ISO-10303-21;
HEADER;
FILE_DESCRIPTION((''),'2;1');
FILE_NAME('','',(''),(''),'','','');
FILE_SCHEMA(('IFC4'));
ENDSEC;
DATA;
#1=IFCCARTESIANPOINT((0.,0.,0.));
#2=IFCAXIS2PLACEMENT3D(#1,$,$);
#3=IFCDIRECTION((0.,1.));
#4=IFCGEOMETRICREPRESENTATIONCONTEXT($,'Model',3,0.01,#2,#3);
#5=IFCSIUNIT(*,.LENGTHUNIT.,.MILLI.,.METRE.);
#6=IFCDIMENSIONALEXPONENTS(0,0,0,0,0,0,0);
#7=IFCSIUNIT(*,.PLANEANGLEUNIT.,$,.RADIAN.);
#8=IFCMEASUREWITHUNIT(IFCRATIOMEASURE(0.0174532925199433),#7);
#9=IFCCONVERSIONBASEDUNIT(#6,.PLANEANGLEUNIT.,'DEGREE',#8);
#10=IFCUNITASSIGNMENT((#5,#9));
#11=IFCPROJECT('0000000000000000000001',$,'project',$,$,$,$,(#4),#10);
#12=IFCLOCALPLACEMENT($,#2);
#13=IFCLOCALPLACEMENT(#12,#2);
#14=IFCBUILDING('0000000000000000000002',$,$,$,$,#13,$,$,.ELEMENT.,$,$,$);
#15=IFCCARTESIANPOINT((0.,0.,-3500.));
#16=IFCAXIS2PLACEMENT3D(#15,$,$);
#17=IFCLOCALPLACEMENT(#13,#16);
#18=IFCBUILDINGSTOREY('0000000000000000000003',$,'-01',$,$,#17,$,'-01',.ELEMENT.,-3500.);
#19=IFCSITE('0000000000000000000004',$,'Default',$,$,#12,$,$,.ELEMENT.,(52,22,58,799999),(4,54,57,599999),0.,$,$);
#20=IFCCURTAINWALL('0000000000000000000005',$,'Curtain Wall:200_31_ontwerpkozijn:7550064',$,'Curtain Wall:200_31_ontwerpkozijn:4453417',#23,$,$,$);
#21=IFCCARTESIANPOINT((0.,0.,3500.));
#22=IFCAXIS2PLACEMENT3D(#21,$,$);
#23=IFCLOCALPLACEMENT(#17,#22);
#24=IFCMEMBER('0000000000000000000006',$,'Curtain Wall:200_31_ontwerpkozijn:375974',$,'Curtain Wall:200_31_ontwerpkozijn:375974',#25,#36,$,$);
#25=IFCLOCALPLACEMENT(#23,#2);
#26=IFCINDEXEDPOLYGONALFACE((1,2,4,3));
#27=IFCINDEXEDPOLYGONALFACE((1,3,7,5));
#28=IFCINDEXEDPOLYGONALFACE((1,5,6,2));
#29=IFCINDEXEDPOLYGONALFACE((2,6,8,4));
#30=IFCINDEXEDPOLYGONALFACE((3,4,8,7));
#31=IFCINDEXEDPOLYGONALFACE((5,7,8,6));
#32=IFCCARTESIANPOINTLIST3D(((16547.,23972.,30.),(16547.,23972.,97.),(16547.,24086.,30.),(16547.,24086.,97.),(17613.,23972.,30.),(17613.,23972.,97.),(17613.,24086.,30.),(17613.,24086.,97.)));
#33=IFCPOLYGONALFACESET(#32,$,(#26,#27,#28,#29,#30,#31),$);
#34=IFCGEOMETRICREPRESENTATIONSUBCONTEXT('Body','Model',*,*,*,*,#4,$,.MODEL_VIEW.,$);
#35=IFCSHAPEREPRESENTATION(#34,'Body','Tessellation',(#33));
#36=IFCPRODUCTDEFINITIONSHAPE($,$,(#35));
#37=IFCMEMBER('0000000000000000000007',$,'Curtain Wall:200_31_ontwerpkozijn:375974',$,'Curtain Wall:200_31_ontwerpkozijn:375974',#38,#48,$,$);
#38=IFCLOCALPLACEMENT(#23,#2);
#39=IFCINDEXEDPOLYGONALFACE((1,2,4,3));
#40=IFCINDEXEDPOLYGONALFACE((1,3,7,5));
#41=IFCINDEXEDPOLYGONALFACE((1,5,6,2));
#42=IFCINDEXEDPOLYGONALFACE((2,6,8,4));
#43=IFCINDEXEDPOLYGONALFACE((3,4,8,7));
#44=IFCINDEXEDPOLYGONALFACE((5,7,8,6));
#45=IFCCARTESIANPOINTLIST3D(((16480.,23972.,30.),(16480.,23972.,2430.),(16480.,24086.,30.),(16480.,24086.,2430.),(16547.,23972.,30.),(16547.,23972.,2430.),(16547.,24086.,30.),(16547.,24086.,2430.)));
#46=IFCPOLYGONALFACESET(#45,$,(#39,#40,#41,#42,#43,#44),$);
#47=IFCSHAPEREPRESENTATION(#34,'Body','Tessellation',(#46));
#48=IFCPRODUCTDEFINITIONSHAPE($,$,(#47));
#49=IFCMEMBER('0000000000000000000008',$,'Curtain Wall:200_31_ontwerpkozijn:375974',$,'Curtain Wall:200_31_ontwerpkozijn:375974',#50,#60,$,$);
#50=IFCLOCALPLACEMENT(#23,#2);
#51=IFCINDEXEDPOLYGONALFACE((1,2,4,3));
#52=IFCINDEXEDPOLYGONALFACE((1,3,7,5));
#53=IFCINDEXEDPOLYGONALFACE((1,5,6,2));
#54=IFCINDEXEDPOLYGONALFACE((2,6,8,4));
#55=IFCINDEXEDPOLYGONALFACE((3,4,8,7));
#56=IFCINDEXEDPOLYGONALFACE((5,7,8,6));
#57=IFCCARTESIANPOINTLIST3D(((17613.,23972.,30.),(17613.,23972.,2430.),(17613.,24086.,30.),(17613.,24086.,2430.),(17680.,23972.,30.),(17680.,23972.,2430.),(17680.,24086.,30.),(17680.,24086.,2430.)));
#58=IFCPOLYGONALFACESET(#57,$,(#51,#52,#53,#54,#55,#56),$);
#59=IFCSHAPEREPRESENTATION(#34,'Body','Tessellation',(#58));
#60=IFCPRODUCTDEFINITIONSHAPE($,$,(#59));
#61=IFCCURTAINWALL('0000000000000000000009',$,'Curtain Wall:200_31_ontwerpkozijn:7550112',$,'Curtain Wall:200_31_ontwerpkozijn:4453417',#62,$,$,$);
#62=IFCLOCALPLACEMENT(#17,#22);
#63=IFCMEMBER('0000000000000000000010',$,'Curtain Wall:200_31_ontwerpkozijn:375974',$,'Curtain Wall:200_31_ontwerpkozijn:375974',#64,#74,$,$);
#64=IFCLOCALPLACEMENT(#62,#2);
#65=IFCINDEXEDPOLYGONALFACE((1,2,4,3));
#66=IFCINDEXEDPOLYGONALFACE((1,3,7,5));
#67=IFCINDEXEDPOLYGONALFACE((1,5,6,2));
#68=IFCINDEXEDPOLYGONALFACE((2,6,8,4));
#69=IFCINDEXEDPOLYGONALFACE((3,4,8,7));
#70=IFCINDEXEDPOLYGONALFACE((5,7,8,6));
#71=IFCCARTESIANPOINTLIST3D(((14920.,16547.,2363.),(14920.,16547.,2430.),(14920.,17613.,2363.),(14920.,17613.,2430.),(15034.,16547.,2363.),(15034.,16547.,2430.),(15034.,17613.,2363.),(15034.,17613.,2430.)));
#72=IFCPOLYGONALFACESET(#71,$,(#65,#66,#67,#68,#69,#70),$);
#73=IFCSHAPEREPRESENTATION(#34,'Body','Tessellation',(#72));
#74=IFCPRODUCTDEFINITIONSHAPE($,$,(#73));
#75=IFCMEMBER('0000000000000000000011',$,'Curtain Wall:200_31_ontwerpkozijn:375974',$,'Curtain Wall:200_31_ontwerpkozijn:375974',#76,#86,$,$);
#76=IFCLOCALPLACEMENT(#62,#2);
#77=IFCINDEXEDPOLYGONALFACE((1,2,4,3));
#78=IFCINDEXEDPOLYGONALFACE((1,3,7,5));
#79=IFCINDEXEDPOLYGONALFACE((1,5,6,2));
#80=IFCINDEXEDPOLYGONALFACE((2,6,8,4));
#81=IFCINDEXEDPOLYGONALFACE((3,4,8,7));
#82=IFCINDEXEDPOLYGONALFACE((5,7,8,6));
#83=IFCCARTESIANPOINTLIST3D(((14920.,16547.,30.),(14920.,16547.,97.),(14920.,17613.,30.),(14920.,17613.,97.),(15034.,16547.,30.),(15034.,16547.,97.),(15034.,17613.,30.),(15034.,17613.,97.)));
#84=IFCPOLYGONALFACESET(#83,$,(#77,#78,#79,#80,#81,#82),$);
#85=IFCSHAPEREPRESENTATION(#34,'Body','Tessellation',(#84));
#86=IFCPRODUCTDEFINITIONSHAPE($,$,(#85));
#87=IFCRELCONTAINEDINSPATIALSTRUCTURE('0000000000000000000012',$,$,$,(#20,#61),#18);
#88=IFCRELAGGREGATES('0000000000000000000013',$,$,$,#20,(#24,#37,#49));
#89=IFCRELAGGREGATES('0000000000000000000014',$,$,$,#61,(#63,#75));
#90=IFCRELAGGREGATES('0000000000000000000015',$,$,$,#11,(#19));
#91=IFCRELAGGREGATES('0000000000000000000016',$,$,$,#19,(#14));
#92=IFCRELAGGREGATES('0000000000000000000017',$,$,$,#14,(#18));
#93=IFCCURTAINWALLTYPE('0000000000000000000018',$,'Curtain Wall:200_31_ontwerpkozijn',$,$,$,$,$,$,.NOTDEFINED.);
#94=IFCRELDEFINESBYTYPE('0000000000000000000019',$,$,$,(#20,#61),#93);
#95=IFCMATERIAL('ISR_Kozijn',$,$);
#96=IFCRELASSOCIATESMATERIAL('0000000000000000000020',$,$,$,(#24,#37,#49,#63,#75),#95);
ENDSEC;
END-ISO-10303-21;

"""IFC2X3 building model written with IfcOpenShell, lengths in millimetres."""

from ifc_helpers import new_model, entity, si_unit, converted_unit, direction, frame, frame_2d, origin, origin_2d_with_axis, place, context, subcontext, project, spatial, rectangle, extrude, material, type_object, element, aggregate, save


model = new_model("IFC2X3")

# Units and contexts
model_context = context("Model", 3, precision=0.01, world=origin(), true_north=direction((0.0, 1.0)))
body_context = subcontext(model_context, "Body", "Model", "MODEL_VIEW")
ifc_project = project(units=[si_unit("LENGTHUNIT", "METRE", prefix="MILLI"), converted_unit("PLANEANGLEUNIT", "DEGREE", entity("IfcRatioMeasure", 0.0174532925199433), si_unit("PLANEANGLEUNIT", "RADIAN"), dimensions=[0, 0, 0, 0, 0, 0, 0])], contexts=[model_context])

# Site, building, storey
site_placement = place(None, origin())
site = spatial("IfcSite", under=ifc_project, at=site_placement, Name="Default", CompositionType="ELEMENT", RefLatitude=(52, 22, 58, 799999), RefLongitude=(4, 54, 57, 599999), RefElevation=0.0)
building_placement = place(site_placement, origin())
building = spatial("IfcBuilding", under=site, at=building_placement, CompositionType="ELEMENT")
storey_placement = place(building_placement, frame((0.0, 0.0, -3500.0)))
storey = spatial("IfcBuildingStorey", under=building, at=storey_placement, Name="-01", LongName="-01", CompositionType="ELEMENT", Elevation=-3500.0)

# Shared definitions
curtain_wall_type = type_object("IfcCurtainWallType", Name="Curtain Wall:200_31_ontwerpkozijn", PredefinedType="NOTDEFINED")
ifc_material = material(Name="ISR_Kozijn")

# Curtain walls, members
curtain_wall_1_placement = place(storey_placement, frame((0.0, 0.0, 3500.0)))
curtain_wall_1 = element("IfcCurtainWall", 1, at=curtain_wall_1_placement, inside=storey, type_object=curtain_wall_type, Name="Curtain Wall:200_31_ontwerpkozijn:7550064", ObjectType="Curtain Wall:200_31_ontwerpkozijn:4453417")
member_1_placement = place(curtain_wall_1_placement, origin())
member_1 = element("IfcMember", 2, at=member_1_placement, material=ifc_material, Name="Curtain Wall:200_31_ontwerpkozijn:375974", ObjectType="Curtain Wall:200_31_ontwerpkozijn:375974", context=body_context, shape_type="SweptSolid", body=[
    extrude(rectangle(XDim=67.0, YDim=114.0, at=origin_2d_with_axis()), frame((17613.0, 24029.0, 63.5), z_axis=(-1.0, 0.0, 0.0), x_axis=(0.0, 0.0, -1.0)), (0.0, 0.0, 1.0), 1066.0),
])
member_2_placement = place(curtain_wall_1_placement, origin())
member_2 = element("IfcMember", 3, at=member_2_placement, material=ifc_material, Name="Curtain Wall:200_31_ontwerpkozijn:375974", ObjectType="Curtain Wall:200_31_ontwerpkozijn:375974", context=body_context, shape_type="SweptSolid", body=[
    extrude(rectangle(XDim=67.0, YDim=114.0, at=frame_2d((0.0, 0.0), x_axis=(1.0, 0.0))), frame((16513.5, 24029.0, 30.0), z_axis=(0.0, 0.0, 1.0), x_axis=(-1.0, 0.0, 0.0)), (0.0, 0.0, 1.0), 2400.0),
])
member_3_placement = place(curtain_wall_1_placement, origin())
member_3 = element("IfcMember", 4, at=member_3_placement, material=ifc_material, Name="Curtain Wall:200_31_ontwerpkozijn:375974", ObjectType="Curtain Wall:200_31_ontwerpkozijn:375974", context=body_context, shape_type="SweptSolid", body=[
    extrude(rectangle(XDim=67.0, YDim=114.0, at=frame_2d((0.0, 0.0), x_axis=(1.0, 0.0))), frame((17646.5, 24029.0, 2430.0), z_axis=(0.0, 0.0, -1.0), x_axis=(-1.0, 0.0, 0.0)), (0.0, 0.0, 1.0), 2400.0),
])
aggregate(curtain_wall_1, [member_1, member_2, member_3])
curtain_wall_2_placement = place(storey_placement, frame((0.0, 0.0, 3500.0)))
curtain_wall_2 = element("IfcCurtainWall", 5, at=curtain_wall_2_placement, inside=storey, type_object=curtain_wall_type, Name="Curtain Wall:200_31_ontwerpkozijn:7550112", ObjectType="Curtain Wall:200_31_ontwerpkozijn:4453417")
member_4_placement = place(curtain_wall_2_placement, origin())
member_4 = element("IfcMember", 6, at=member_4_placement, material=ifc_material, Name="Curtain Wall:200_31_ontwerpkozijn:375974", ObjectType="Curtain Wall:200_31_ontwerpkozijn:375974", context=body_context, shape_type="SweptSolid", body=[
    extrude(rectangle(XDim=67.0, YDim=114.0, at=origin_2d_with_axis()), frame((14977.0, 17613.0, 2396.5), z_axis=(0.0, -1.0, 0.0), x_axis=(0.0, 0.0, -1.0)), (0.0, 0.0, 1.0), 1066.0),
])
member_5_placement = place(curtain_wall_2_placement, origin())
member_5 = element("IfcMember", 7, at=member_5_placement, material=ifc_material, Name="Curtain Wall:200_31_ontwerpkozijn:375974", ObjectType="Curtain Wall:200_31_ontwerpkozijn:375974", context=body_context, shape_type="SweptSolid", body=[
    extrude(rectangle(XDim=67.0, YDim=114.0, at=origin_2d_with_axis()), frame((14977.0, 16547.0, 63.5), z_axis=(0.0, 1.0, 0.0), x_axis=(0.0, 0.0, -1.0)), (0.0, 0.0, 1.0), 1066.0),
])
aggregate(curtain_wall_2, [member_4, member_5])

save(model, "model.ifc")
